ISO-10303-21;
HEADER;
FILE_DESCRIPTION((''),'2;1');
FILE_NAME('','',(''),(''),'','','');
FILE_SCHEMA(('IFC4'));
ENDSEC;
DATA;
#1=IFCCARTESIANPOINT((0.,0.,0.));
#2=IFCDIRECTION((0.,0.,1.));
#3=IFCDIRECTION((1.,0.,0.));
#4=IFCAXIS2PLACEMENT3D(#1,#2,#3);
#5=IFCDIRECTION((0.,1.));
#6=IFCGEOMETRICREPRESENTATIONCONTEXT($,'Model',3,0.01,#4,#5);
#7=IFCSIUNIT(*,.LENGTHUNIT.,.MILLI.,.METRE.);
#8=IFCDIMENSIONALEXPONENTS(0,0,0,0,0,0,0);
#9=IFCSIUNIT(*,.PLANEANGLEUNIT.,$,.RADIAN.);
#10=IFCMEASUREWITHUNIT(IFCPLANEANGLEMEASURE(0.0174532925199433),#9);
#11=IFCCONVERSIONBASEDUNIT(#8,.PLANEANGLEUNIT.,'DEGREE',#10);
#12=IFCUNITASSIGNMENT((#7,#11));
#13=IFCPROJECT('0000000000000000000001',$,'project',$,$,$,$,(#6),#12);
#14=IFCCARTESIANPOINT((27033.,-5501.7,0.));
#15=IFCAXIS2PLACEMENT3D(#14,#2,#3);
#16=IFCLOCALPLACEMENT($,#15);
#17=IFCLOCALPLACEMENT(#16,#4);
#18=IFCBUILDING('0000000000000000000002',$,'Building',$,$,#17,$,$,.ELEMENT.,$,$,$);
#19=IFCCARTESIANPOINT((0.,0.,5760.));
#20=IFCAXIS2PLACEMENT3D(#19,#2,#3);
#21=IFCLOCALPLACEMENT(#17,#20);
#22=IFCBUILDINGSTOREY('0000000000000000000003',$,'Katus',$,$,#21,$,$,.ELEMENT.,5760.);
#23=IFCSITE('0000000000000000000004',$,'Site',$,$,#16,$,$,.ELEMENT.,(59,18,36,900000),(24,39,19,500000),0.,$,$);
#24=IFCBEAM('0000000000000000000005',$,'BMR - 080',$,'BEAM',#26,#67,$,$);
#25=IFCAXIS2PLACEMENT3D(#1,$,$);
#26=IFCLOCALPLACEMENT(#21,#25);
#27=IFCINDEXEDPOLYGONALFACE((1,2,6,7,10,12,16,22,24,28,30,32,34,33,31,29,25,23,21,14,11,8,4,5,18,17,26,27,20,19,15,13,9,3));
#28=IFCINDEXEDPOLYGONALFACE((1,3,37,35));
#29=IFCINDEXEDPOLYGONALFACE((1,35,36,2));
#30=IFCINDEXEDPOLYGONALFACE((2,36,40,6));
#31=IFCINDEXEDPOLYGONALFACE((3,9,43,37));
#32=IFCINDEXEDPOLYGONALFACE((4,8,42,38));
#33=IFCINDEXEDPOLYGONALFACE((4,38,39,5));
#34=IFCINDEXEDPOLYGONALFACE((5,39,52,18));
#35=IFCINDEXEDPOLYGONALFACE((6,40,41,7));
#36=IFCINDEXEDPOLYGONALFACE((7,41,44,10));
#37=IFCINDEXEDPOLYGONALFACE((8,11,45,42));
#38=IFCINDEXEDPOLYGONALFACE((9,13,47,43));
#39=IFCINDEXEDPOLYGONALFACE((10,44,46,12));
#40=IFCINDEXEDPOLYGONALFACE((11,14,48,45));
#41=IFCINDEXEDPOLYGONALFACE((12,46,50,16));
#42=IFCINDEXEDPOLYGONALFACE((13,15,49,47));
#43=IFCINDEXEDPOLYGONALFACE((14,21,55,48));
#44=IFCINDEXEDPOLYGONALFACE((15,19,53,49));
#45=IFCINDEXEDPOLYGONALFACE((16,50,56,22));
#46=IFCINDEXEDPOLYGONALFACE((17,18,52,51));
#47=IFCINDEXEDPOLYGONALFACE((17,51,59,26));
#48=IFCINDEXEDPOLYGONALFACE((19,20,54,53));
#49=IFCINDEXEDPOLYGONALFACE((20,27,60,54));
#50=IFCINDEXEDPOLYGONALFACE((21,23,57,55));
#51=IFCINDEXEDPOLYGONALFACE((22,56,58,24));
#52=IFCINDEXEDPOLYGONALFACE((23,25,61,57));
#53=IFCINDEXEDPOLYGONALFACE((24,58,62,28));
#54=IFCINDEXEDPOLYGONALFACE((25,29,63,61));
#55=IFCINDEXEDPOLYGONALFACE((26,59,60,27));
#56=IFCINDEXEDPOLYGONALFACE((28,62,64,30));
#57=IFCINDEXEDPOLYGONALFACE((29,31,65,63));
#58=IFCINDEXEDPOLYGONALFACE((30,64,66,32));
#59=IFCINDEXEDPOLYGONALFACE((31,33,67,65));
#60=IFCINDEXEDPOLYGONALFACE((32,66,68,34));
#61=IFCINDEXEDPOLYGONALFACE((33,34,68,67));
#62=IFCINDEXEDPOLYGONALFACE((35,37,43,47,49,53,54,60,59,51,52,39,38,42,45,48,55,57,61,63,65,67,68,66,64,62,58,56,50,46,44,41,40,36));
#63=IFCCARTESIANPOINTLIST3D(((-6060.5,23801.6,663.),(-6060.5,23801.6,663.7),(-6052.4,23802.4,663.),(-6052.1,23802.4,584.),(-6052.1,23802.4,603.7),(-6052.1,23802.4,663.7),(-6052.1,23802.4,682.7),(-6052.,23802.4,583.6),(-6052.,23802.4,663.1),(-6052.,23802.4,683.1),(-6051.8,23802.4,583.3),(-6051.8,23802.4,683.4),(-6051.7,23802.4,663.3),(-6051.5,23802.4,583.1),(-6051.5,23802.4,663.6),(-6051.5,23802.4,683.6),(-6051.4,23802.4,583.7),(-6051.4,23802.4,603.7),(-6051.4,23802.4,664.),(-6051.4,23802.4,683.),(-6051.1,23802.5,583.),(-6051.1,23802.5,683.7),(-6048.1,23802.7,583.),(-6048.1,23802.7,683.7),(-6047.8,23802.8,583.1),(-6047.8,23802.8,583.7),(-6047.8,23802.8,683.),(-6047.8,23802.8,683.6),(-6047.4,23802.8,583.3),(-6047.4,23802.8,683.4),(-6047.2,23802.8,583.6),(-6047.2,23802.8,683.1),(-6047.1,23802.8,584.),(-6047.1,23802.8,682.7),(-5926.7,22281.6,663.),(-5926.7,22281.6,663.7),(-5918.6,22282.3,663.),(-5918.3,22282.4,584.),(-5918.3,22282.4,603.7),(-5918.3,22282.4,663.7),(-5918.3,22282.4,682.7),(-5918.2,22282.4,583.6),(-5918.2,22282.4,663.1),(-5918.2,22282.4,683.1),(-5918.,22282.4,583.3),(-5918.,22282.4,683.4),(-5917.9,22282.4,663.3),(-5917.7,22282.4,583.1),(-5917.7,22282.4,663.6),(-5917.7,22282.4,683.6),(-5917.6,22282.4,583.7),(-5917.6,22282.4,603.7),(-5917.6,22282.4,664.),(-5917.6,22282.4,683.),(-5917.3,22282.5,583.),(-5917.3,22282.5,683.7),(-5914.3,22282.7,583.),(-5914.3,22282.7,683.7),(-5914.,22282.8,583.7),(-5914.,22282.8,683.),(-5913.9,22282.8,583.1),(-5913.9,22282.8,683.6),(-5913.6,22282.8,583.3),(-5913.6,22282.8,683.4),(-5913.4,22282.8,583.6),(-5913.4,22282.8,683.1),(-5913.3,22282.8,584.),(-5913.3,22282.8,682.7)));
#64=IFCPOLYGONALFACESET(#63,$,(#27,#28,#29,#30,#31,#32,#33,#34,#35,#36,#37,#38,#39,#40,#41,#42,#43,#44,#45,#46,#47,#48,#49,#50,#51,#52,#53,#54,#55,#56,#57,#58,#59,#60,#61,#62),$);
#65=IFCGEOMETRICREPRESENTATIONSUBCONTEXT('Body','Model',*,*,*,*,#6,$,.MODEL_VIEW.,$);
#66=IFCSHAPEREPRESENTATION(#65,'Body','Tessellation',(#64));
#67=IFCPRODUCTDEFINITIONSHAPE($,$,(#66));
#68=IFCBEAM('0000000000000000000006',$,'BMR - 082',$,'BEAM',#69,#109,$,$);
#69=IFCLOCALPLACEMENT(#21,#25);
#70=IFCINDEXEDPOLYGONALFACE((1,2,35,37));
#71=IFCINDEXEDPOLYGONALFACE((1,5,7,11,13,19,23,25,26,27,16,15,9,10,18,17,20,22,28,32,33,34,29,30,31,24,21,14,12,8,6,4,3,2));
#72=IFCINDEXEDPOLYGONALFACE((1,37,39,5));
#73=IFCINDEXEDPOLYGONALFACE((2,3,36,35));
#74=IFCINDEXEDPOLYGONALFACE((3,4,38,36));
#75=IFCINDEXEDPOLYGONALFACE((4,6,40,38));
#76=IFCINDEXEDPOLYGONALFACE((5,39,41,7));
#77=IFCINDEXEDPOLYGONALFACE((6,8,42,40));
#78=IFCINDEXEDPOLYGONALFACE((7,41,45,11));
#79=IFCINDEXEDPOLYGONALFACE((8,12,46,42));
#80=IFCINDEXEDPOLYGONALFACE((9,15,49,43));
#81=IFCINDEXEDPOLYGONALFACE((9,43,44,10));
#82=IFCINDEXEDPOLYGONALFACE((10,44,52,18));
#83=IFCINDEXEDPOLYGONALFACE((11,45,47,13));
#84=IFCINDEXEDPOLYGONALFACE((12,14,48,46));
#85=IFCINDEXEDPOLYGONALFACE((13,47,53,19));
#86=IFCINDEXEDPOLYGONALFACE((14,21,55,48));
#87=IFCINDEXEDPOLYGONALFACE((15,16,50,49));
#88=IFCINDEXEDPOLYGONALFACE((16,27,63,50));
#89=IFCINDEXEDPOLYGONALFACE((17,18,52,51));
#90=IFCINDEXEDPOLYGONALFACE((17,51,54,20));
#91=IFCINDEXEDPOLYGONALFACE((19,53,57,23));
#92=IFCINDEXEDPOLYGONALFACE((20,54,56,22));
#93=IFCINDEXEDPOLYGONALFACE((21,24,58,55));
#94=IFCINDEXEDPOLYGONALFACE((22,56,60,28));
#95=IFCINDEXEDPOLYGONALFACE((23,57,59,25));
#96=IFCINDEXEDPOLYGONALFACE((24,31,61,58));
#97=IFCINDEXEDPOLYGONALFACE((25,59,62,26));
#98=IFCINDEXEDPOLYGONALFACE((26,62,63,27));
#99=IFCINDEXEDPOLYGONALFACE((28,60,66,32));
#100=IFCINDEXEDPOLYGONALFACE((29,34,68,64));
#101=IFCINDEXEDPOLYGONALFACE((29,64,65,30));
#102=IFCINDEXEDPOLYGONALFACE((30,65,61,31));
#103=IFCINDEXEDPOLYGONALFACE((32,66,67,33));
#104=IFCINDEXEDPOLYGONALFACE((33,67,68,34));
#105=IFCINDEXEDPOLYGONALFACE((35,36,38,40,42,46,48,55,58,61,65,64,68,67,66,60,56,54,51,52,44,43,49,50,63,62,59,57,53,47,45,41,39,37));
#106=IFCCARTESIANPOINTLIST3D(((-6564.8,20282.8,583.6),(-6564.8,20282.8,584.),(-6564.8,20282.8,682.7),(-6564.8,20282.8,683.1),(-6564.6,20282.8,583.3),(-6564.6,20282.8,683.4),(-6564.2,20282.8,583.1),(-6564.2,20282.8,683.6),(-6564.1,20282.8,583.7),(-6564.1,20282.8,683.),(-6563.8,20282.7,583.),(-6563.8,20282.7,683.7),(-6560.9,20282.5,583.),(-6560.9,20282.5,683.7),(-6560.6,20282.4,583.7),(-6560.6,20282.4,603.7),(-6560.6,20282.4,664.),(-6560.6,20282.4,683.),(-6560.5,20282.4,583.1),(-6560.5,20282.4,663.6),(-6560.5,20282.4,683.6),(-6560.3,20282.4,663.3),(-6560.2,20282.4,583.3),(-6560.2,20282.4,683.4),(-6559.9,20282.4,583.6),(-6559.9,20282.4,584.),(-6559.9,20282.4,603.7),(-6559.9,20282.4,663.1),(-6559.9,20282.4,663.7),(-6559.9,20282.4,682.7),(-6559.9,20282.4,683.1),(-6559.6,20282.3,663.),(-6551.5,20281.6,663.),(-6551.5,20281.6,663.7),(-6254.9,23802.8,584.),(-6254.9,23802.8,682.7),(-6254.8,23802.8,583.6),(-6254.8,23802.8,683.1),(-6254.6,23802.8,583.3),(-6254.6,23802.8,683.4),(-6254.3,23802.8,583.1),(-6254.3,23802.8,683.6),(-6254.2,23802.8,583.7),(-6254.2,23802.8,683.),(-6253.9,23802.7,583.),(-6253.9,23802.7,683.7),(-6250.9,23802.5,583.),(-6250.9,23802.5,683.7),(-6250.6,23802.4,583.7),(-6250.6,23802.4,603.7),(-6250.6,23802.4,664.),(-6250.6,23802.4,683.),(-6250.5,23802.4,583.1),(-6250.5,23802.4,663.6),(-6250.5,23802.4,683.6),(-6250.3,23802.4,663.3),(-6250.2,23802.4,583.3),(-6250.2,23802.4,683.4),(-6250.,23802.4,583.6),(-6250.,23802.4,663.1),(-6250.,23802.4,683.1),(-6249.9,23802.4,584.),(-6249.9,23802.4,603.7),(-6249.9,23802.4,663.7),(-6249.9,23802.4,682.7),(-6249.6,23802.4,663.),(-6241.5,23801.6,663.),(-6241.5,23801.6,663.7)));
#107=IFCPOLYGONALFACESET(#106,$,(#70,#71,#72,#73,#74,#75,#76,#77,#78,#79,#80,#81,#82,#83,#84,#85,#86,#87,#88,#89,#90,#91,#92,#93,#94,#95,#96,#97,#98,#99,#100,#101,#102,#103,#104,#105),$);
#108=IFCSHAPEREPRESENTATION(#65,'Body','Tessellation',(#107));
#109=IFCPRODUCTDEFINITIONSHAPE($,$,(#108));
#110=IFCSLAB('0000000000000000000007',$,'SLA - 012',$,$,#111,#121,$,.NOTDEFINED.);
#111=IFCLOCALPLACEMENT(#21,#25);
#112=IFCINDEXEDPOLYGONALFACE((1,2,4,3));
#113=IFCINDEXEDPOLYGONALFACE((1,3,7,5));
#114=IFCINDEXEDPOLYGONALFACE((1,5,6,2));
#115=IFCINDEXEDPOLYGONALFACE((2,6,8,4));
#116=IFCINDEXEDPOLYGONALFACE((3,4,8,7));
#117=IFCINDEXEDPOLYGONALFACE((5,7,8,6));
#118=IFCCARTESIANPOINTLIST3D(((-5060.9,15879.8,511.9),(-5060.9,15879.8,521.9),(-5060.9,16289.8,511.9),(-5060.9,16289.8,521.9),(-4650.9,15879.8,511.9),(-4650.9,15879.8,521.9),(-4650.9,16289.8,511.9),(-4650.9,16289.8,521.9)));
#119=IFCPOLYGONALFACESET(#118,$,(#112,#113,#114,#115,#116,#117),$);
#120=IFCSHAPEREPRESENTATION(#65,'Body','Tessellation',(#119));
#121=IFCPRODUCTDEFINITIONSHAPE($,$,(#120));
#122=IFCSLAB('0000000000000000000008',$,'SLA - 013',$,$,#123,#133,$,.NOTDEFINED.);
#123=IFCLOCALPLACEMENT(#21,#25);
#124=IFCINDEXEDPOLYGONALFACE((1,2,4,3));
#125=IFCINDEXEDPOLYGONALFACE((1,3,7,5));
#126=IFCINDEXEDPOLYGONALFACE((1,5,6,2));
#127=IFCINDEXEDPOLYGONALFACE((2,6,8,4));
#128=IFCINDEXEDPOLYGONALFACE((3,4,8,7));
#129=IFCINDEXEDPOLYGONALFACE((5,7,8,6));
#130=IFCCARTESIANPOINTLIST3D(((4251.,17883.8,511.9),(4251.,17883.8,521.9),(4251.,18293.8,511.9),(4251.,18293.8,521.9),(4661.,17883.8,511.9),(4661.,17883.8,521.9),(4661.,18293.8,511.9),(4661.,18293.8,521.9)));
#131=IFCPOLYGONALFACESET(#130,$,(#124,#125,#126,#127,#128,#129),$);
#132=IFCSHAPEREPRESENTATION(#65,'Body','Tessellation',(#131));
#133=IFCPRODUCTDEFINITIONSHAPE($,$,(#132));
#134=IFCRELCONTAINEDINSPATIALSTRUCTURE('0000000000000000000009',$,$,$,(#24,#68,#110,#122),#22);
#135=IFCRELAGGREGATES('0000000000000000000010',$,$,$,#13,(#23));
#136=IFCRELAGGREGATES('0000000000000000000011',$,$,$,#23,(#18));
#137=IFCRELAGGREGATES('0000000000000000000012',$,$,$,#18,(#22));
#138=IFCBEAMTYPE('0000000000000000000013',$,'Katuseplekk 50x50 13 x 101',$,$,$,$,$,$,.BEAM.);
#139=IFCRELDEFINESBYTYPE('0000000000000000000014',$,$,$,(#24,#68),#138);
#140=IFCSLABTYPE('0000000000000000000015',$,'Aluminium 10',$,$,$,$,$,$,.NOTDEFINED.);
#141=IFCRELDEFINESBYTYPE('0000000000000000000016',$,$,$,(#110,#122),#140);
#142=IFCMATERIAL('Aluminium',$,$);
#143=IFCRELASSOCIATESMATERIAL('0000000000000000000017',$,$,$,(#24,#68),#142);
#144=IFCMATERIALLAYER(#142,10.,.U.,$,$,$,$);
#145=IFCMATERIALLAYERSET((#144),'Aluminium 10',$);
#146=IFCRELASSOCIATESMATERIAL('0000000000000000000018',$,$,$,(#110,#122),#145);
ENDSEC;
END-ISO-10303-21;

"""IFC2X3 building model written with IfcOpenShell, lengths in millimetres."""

from ifc_helpers import new_model, entity, si_unit, converted_unit, point, direction, frame, frame_2d, origin_with_axes, place, context, subcontext, project, spatial, polyline, circle_curve, parameter, trimmed, segment, composite_curve, outline, extrude, material, layer, layer_set, layer_usage, type_object, element, save


model = new_model("IFC2X3")

# Units and contexts
model_context = context("Model", 3, precision=0.01, world=origin_with_axes(), true_north=direction((0.0, 1.0)))
body_context = subcontext(model_context, "Body", "Model", "MODEL_VIEW")
ifc_project = project(units=[si_unit("LENGTHUNIT", "METRE", prefix="MILLI"), converted_unit("PLANEANGLEUNIT", "DEGREE", entity("IfcPlaneAngleMeasure", 0.0174532925199433), si_unit("PLANEANGLEUNIT", "RADIAN"), dimensions=[0, 0, 0, 0, 0, 0, 0])], contexts=[model_context])

# Site, building, storey
site_placement = place(None, frame((27033.0, -5501.7, 0.0), z_axis=(0.0, 0.0, 1.0), x_axis=(1.0, 0.0, 0.0)))
site = spatial("IfcSite", under=ifc_project, at=site_placement, Name="Site", CompositionType="ELEMENT", RefLatitude=(59, 18, 36, 900000), RefLongitude=(24, 39, 19, 500000), RefElevation=0.0)
building_placement = place(site_placement, origin_with_axes())
building = spatial("IfcBuilding", under=site, at=building_placement, Name="Building", CompositionType="ELEMENT")
storey_placement = place(building_placement, frame((0.0, 0.0, 5760.0), z_axis=(0.0, 0.0, 1.0), x_axis=(1.0, 0.0, 0.0)))
storey = spatial("IfcBuildingStorey", under=building, at=storey_placement, Name="Katus", CompositionType="ELEMENT", Elevation=5760.0)

# Beams
ifc_material_1 = material(Name="Aluminium")
beam_type = type_object("IfcBeamType", Name="Katuseplekk 50x50 13 x 101", PredefinedType="BEAM")
beam_1_placement = place(storey_placement, frame((-5926.0, 22281.7, 663.0), z_axis=(0.0, 0.0, 1.0), x_axis=(0.996146, 0.087713, 0.0)))
element("IfcBeam", 1, at=beam_1_placement, inside=storey, type_object=beam_type, material=ifc_material_1, Name="BMR - 080", ObjectType="BEAM", context=body_context, shape_type="SweptSolid", body=[
    extrude(outline(composite_curve([segment(polyline([(-0.7, 0.0), (7.4, 0.0)]), True, "CONTINUOUS"), segment(trimmed(circle_curve(frame_2d((7.4, 1.0), x_axis=(0.0, -1.0)), 1.0), [point((7.4, 0.0)), parameter(0.0)], [point((8.4, 1.0)), parameter(90.0)], True, "CARTESIAN"), True, "CONTINUOUS"), segment(polyline([(8.4, 1.0), (8.4, 20.0), (12.0, 20.0), (12.0, -79.3), (8.4, -79.3), (8.4, -59.3), (7.7, -59.3), (7.7, -79.0)]), True, "CONTINUOUS"), segment(trimmed(circle_curve(frame_2d((8.7, -79.0), x_axis=(-1.0, 0.0)), 1.0), [point((7.7, -79.0)), parameter(0.0)], [point((8.7, -80.0)), parameter(90.0)], True, "CARTESIAN"), True, "CONTINUOUS"), segment(polyline([(8.7, -80.0), (11.7, -80.0)]), True, "CONTINUOUS"), segment(trimmed(circle_curve(frame_2d((11.7, -79.0), x_axis=(0.0, -1.0)), 1.0), [point((11.7, -80.0)), parameter(0.0)], [point((12.7, -79.0)), parameter(90.0)], True, "CARTESIAN"), True, "CONTINUOUS"), segment(polyline([(12.7, -79.0), (12.7, 19.7)]), True, "CONTINUOUS"), segment(trimmed(circle_curve(frame_2d((11.7, 19.7), x_axis=(1.0, 0.0)), 1.0), [point((12.7, 19.7)), parameter(0.0)], [point((11.7, 20.7)), parameter(90.0)], True, "CARTESIAN"), True, "CONTINUOUS"), segment(polyline([(11.7, 20.7), (8.7, 20.7)]), True, "CONTINUOUS"), segment(trimmed(circle_curve(frame_2d((8.7, 19.7), x_axis=(0.0, 1.0)), 1.0), [point((8.7, 20.7)), parameter(0.0)], [point((7.7, 19.7)), parameter(90.0)], True, "CARTESIAN"), True, "CONTINUOUS"), segment(polyline([(7.7, 19.7), (7.7, 0.7), (-0.7, 0.7), (-0.7, 0.0)]), True, "CONTINUOUS")], self_intersect=False)), frame((0.0, 1525.9, 0.0), z_axis=(0.0, -1.0, 0.0), x_axis=(1.0, 0.0, 0.0)), (0.0, 0.0, 1.0), 1525.9),
])
beam_2_placement = place(storey_placement, frame((-6242.2, 23801.7, 663.0), z_axis=(0.0, 0.0, 1.0), x_axis=(-0.996146, 0.087713, 0.0)))
element("IfcBeam", 2, at=beam_2_placement, inside=storey, type_object=beam_type, material=ifc_material_1, Name="BMR - 082", ObjectType="BEAM", context=body_context, shape_type="SweptSolid", body=[
    extrude(outline(composite_curve([segment(polyline([(-0.7, 0.0), (7.4, 0.0)]), True, "CONTINUOUS"), segment(trimmed(circle_curve(frame_2d((7.4, 1.0), x_axis=(0.0, -1.0)), 1.0), [point((7.4, 0.0)), parameter(0.0)], [point((8.4, 1.0)), parameter(90.0)], True, "CARTESIAN"), True, "CONTINUOUS"), segment(polyline([(8.4, 1.0), (8.4, 20.0), (12.0, 20.0), (12.0, -79.3), (8.4, -79.3), (8.4, -59.3), (7.7, -59.3), (7.7, -79.0)]), True, "CONTINUOUS"), segment(trimmed(circle_curve(frame_2d((8.7, -79.0), x_axis=(-1.0, 0.0)), 1.0), [point((7.7, -79.0)), parameter(0.0)], [point((8.7, -80.0)), parameter(90.0)], True, "CARTESIAN"), True, "CONTINUOUS"), segment(polyline([(8.7, -80.0), (11.7, -80.0)]), True, "CONTINUOUS"), segment(trimmed(circle_curve(frame_2d((11.7, -79.0), x_axis=(0.0, -1.0)), 1.0), [point((11.7, -80.0)), parameter(0.0)], [point((12.7, -79.0)), parameter(90.0)], True, "CARTESIAN"), True, "CONTINUOUS"), segment(polyline([(12.7, -79.0), (12.7, 19.7)]), True, "CONTINUOUS"), segment(trimmed(circle_curve(frame_2d((11.7, 19.7), x_axis=(1.0, 0.0)), 1.0), [point((12.7, 19.7)), parameter(0.0)], [point((11.7, 20.7)), parameter(90.0)], True, "CARTESIAN"), True, "CONTINUOUS"), segment(polyline([(11.7, 20.7), (8.7, 20.7)]), True, "CONTINUOUS"), segment(trimmed(circle_curve(frame_2d((8.7, 19.7), x_axis=(0.0, 1.0)), 1.0), [point((8.7, 20.7)), parameter(0.0)], [point((7.7, 19.7)), parameter(90.0)], True, "CARTESIAN"), True, "CONTINUOUS"), segment(polyline([(7.7, 19.7), (7.7, 0.7), (-0.7, 0.7), (-0.7, 0.0)]), True, "CONTINUOUS")], self_intersect=False)), frame((0.0, 3533.6, 0.0), z_axis=(0.0, -1.0, 0.0), x_axis=(1.0, 0.0, 0.0)), (0.0, 0.0, 1.0), 3533.6),
])

# Slabs
ifc_layer_1 = layer(ifc_material_1, 10.0, ventilated="UNKNOWN")
ifc_layer_set_1 = layer_set([ifc_layer_1], Name="Aluminium 10")
ifc_layer_usage_1 = layer_usage(ifc_layer_set_1, "AXIS3", "NEGATIVE", 10.0)
slab_type_1 = type_object("IfcSlabType", Name="Aluminium 10", PredefinedType="NOTDEFINED")
slab_1_placement = place(storey_placement, frame((-5060.9, 15879.8, 511.9), z_axis=(0.0, 0.0, 1.0), x_axis=(1.0, 0.0, 0.0)))
element("IfcSlab", 3, at=slab_1_placement, inside=storey, type_object=slab_type_1, material=ifc_layer_usage_1, Name="SLA - 012", PredefinedType="NOTDEFINED", context=body_context, shape_type="SweptSolid", body=[
    extrude(outline(polyline([(0.0, 0.0), (410.0, 0.0), (410.0, 410.0), (0.0, 410.0), (0.0, 0.0)])), origin_with_axes(), (0.0, 0.0, 1.0), 10.0),
])
ifc_layer_usage_2 = layer_usage(ifc_layer_set_1, "AXIS3", "NEGATIVE", 10.0)
slab_2_placement = place(storey_placement, frame((4251.0, 17883.8, 511.9), z_axis=(0.0, 0.0, 1.0), x_axis=(1.0, 0.0, 0.0)))
element("IfcSlab", 4, at=slab_2_placement, inside=storey, type_object=slab_type_1, material=ifc_layer_usage_2, Name="SLA - 013", PredefinedType="NOTDEFINED", context=body_context, shape_type="SweptSolid", body=[
    extrude(outline(polyline([(0.0, 0.0), (410.0, 0.0), (410.0, 410.0), (0.0, 410.0), (0.0, 0.0)])), origin_with_axes(), (0.0, 0.0, 1.0), 10.0),
])

save(model, "model.ifc")
